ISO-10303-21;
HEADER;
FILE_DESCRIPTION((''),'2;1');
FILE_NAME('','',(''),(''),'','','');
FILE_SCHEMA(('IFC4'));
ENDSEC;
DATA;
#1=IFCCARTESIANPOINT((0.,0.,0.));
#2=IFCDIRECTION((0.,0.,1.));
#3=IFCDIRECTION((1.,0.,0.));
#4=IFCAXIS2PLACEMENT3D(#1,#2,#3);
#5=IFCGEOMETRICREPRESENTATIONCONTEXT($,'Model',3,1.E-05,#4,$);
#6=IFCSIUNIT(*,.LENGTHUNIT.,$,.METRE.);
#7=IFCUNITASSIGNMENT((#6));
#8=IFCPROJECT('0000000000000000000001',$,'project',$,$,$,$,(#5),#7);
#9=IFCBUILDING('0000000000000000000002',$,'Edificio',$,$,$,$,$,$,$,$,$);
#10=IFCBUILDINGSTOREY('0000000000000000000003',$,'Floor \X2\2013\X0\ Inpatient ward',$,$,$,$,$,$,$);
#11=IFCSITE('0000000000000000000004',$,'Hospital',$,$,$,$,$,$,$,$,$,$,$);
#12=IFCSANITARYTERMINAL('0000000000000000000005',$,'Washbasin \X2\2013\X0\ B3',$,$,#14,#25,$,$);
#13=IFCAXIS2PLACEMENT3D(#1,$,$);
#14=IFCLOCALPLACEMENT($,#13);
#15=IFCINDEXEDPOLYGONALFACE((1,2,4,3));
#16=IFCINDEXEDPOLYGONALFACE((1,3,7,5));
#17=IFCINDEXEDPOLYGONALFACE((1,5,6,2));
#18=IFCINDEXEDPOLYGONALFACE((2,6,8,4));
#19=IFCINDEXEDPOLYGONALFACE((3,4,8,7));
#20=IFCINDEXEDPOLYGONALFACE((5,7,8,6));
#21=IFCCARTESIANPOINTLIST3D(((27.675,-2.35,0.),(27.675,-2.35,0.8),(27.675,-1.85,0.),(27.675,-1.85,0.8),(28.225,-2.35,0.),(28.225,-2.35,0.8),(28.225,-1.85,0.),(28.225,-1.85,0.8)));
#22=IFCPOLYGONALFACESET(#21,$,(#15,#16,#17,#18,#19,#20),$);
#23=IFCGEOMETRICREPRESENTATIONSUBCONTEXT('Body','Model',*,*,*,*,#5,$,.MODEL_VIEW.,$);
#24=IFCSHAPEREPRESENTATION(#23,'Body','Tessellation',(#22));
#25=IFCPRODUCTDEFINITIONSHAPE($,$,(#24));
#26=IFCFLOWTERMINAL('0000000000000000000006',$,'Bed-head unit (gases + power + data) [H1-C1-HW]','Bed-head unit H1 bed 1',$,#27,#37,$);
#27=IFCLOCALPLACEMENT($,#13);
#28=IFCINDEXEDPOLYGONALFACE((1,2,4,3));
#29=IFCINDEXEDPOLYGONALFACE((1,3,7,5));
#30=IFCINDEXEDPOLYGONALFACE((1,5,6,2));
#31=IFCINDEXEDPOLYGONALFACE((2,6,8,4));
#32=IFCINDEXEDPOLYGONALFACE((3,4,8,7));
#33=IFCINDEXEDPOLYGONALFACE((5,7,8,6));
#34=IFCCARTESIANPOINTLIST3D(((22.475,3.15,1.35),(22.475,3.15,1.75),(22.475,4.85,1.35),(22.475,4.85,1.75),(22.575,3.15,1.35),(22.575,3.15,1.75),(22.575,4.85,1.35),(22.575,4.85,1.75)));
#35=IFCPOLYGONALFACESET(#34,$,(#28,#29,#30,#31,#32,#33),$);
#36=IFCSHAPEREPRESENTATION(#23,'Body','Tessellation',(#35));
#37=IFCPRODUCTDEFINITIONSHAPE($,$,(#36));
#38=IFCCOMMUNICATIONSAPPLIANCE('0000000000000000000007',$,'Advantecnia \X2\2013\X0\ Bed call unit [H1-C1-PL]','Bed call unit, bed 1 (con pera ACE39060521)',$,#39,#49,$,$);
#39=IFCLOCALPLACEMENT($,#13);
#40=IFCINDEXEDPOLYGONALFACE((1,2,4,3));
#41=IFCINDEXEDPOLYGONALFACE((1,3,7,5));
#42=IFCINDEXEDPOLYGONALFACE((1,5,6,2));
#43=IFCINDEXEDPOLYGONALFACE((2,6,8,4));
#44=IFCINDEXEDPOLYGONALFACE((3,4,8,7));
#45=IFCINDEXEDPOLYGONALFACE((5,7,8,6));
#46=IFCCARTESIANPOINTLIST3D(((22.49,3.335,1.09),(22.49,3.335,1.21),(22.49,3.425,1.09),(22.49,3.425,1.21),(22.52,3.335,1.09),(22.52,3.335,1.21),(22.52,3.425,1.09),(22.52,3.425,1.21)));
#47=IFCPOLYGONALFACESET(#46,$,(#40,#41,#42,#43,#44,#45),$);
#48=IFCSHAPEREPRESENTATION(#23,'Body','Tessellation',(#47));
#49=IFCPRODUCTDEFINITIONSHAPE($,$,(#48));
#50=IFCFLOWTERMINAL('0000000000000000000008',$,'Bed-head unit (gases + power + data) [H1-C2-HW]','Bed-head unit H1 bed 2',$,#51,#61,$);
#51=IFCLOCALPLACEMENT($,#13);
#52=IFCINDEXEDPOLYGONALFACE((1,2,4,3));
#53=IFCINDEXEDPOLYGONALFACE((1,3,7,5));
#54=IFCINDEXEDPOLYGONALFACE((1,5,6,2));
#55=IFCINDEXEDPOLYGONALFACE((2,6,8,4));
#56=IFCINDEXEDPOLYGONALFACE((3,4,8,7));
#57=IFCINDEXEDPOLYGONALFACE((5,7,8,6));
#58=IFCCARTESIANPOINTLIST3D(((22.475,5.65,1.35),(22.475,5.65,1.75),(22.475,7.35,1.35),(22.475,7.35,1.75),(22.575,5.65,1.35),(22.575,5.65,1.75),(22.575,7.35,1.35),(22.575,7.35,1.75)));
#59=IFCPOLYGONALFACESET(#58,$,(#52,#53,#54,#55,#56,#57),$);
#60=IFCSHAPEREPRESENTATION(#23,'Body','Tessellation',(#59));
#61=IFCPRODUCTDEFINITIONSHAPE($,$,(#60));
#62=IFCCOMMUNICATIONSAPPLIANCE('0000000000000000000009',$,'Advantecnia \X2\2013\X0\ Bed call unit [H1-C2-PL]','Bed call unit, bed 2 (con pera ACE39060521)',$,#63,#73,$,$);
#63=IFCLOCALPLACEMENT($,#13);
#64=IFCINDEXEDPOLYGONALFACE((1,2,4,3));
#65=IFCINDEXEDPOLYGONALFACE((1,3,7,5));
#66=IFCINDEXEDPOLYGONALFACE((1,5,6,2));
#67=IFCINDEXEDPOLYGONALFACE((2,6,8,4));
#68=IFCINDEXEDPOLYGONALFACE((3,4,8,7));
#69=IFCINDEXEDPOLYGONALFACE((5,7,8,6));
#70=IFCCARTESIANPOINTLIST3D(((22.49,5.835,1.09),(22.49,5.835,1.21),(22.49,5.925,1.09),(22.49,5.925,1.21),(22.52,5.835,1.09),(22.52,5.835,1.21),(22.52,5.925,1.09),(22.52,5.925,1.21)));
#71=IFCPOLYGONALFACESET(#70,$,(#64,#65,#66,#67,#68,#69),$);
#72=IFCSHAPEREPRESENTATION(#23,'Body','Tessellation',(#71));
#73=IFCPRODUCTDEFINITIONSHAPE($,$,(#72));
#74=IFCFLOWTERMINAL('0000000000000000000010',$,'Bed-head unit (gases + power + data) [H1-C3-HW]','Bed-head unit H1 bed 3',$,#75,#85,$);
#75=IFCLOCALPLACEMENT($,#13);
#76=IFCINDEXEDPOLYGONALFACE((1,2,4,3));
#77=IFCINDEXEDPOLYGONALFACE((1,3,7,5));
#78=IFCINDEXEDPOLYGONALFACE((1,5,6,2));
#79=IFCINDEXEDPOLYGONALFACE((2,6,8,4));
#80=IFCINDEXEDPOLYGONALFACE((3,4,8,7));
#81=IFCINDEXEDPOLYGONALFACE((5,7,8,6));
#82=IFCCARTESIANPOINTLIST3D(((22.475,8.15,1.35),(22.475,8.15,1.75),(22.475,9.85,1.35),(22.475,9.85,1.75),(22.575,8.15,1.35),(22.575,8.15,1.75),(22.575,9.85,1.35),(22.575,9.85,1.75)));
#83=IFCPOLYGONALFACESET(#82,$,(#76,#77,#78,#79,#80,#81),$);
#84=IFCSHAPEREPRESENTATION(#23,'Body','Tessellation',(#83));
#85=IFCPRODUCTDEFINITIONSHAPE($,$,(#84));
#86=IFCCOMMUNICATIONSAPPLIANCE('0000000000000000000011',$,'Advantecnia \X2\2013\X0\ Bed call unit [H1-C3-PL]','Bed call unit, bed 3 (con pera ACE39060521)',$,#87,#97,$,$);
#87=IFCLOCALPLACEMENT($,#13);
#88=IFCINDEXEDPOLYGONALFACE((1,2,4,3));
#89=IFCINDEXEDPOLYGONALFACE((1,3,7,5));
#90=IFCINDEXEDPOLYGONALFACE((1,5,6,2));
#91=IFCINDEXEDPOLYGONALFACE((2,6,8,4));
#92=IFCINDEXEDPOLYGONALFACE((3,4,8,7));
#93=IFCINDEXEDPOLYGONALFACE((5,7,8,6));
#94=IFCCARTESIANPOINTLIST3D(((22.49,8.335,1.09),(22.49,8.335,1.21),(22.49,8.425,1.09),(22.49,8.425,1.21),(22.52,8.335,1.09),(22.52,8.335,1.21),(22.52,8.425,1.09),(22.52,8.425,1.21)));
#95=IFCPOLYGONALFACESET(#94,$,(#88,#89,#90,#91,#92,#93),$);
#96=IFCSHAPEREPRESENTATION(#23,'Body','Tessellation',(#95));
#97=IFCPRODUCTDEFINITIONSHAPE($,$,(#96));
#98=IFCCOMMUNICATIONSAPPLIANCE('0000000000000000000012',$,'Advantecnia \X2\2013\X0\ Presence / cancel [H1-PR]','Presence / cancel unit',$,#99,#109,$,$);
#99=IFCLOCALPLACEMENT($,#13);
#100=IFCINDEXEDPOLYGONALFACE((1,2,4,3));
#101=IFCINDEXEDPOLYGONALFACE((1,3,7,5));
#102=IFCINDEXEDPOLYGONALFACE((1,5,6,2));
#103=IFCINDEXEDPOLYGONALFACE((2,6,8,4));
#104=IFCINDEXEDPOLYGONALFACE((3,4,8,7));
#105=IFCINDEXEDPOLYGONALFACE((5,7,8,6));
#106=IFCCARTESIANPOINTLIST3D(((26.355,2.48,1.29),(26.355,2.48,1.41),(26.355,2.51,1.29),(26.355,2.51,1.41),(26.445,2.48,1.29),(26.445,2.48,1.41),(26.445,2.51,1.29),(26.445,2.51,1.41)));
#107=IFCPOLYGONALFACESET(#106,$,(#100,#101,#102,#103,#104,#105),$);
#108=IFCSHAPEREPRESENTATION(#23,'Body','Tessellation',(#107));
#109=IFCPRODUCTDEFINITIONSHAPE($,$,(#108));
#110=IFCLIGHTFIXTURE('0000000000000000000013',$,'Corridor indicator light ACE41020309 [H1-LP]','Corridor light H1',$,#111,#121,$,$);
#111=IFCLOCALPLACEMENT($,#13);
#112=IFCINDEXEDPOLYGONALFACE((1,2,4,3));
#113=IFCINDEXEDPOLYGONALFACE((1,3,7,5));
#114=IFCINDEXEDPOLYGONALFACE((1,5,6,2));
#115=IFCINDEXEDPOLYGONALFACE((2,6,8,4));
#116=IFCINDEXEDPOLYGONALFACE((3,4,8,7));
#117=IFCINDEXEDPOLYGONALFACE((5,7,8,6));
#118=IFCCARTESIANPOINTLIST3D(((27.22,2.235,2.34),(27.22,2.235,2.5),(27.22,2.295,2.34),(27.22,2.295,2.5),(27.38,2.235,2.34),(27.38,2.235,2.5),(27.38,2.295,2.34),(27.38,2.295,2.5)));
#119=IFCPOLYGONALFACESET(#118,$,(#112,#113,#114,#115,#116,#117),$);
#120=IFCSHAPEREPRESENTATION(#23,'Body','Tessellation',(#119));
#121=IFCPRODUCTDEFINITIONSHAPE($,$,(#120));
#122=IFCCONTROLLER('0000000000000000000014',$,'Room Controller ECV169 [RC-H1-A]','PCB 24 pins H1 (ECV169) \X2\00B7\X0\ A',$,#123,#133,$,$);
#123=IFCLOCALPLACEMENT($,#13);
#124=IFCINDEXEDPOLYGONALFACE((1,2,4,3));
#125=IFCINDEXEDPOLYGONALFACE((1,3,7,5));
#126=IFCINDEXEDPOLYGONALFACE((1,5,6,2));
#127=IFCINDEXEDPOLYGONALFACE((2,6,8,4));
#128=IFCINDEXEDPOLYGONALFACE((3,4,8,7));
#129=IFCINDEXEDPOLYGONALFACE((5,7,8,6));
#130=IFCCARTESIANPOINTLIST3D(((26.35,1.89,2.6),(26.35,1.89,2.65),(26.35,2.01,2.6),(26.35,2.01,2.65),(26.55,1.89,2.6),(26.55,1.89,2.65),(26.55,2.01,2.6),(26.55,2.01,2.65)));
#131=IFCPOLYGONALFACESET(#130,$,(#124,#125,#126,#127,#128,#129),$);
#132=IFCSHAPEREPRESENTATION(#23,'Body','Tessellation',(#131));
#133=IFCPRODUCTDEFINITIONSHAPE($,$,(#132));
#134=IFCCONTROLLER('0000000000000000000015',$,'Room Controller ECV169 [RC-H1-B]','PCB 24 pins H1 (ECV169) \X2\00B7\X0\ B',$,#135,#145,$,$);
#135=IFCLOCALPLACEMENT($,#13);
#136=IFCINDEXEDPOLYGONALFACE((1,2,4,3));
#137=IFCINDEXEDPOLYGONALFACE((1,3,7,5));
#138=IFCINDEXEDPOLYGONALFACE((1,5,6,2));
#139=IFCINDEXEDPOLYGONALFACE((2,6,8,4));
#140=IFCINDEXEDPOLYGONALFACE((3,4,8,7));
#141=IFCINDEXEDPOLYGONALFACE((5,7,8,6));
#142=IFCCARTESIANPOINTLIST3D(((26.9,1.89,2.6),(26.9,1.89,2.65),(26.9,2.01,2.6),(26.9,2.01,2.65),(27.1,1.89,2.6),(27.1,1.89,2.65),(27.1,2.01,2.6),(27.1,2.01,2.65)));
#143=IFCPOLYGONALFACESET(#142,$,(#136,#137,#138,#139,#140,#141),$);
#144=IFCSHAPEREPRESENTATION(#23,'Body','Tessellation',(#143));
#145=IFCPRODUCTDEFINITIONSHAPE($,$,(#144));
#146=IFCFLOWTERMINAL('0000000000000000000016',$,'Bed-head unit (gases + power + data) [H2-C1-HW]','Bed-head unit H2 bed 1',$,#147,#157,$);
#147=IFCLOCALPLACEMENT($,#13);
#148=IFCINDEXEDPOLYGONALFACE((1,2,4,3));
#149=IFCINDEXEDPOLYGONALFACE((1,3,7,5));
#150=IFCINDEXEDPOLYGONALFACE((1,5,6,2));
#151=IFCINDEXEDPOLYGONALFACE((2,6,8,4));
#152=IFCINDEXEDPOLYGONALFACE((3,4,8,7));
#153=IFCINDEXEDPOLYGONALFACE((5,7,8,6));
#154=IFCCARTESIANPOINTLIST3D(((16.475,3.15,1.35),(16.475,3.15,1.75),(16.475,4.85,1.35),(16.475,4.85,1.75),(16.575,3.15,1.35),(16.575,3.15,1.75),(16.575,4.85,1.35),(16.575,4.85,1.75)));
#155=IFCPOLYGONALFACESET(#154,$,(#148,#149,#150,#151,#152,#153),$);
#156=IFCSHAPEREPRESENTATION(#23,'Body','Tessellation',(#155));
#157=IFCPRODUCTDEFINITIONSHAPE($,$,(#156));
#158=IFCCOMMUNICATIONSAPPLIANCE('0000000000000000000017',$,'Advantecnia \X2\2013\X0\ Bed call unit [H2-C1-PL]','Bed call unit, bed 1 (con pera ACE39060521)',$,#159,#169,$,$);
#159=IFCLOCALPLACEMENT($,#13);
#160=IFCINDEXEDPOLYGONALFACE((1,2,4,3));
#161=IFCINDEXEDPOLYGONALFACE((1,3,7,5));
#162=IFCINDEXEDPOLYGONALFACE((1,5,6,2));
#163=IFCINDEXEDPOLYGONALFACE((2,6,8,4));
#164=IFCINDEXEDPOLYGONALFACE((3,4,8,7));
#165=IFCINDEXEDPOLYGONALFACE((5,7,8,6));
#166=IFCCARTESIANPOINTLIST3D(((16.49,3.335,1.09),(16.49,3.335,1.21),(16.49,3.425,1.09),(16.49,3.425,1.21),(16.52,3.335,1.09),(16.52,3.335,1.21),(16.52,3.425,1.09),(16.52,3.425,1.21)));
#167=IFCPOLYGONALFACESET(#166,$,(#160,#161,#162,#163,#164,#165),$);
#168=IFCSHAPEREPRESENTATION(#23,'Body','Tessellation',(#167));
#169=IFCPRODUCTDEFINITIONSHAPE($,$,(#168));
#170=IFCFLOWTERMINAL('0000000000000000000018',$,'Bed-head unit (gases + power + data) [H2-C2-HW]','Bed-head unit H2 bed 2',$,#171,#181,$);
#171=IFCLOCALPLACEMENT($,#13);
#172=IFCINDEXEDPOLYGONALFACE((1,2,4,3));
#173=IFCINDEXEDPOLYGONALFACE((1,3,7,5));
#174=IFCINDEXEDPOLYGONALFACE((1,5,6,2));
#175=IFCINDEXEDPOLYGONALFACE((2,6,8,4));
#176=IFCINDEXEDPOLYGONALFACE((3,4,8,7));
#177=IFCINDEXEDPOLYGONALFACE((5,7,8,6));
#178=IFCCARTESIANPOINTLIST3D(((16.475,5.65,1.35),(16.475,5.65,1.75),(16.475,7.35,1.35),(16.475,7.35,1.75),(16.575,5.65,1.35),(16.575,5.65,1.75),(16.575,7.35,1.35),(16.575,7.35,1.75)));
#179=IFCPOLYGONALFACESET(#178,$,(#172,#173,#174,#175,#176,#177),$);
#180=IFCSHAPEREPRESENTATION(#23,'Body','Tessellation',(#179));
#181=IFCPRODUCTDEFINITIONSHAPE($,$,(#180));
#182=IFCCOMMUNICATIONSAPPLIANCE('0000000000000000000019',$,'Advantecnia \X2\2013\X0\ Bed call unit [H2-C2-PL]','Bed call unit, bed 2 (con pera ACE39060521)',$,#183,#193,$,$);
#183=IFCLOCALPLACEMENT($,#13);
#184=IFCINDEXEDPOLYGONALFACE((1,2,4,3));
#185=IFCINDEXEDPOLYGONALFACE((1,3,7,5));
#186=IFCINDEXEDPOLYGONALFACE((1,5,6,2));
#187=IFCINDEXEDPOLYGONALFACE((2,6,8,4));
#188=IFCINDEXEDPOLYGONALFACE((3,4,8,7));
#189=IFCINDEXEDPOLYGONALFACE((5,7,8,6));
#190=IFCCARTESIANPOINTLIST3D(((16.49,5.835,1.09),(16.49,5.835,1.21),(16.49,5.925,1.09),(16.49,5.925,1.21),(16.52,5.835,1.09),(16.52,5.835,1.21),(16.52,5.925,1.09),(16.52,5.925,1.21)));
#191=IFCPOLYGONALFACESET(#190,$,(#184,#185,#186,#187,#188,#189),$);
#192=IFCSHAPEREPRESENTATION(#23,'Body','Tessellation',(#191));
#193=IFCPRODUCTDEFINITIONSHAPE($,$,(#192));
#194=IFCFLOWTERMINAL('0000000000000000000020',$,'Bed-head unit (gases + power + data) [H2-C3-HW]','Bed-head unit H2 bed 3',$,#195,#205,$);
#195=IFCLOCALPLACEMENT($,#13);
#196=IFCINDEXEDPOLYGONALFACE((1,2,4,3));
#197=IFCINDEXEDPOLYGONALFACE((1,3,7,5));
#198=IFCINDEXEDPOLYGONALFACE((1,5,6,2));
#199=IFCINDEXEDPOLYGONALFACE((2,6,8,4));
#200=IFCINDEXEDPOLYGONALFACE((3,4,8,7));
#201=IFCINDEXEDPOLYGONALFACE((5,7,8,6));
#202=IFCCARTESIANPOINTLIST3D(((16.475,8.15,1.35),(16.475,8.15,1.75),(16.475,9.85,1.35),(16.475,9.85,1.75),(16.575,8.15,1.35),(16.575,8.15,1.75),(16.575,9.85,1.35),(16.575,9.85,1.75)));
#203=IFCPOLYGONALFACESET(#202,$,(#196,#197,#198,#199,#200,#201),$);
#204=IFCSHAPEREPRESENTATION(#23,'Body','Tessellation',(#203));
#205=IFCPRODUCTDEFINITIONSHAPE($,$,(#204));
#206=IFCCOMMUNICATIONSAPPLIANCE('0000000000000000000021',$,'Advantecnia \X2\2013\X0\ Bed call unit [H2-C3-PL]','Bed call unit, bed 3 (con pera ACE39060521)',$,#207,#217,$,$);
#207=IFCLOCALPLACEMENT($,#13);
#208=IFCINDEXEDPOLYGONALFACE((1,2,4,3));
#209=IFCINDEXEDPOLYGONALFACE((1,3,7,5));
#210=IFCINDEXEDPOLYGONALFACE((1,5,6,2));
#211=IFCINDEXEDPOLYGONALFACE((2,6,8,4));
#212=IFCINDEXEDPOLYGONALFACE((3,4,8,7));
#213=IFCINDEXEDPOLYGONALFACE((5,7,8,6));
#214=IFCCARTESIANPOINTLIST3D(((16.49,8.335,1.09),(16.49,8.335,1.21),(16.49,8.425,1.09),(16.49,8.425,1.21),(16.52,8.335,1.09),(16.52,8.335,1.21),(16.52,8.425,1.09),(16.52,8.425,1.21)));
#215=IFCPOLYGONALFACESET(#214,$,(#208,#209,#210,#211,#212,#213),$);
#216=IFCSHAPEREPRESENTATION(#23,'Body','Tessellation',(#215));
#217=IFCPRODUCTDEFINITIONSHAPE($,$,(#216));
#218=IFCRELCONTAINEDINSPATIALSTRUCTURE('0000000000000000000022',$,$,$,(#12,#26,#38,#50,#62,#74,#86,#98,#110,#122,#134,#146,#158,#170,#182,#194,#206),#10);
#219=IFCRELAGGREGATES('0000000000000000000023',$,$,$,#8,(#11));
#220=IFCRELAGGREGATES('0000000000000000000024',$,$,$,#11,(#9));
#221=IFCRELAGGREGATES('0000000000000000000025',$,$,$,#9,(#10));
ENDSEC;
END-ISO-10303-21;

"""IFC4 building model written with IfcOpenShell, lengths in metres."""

from ifc_helpers import new_model, si_unit, frame, origin_with_axes, context, subcontext, project, spatial, line, indexed_curve, outline, extrude, element, save


model = new_model("IFC4")

# Units and contexts
model_context = context("Model", 3, precision=1e-05, world=origin_with_axes())
body_context = subcontext(model_context, "Body", "Model", "MODEL_VIEW")
ifc_project = project(units=[si_unit("LENGTHUNIT", "METRE")], contexts=[model_context])

# Site, building, storey
site = spatial("IfcSite", under=ifc_project, Name="Hospital")
building = spatial("IfcBuilding", under=site, Name="Edificio")
storey = spatial("IfcBuildingStorey", under=building, Name="Floor – Inpatient ward")

# Sanitary terminal
element("IfcSanitaryTerminal", 1, inside=storey, Name="Washbasin – B3", context=body_context, shape_type="SweptSolid", body=[
    extrude(outline(indexed_curve([(0.0, 0.0), (0.55, 0.0), (0.55, 0.5), (0.0, 0.5)], segments=[line(1, 2, 3, 4, 1)])), frame((27.675, -2.35, 0.0), z_axis=(0.0, 0.0, 1.0), x_axis=(1.0, 0.0, 0.0)), (0.0, 0.0, 1.0), 0.8),
])

# Flow terminal
element("IfcFlowTerminal", 2, inside=storey, Name="Bed-head unit (gases + power + data) [H1-C1-HW]", Description="Bed-head unit H1 bed 1", context=body_context, shape_type="SweptSolid", body=[
    extrude(outline(indexed_curve([(0.0, 0.0), (0.1, 0.0), (0.1, 1.7), (0.0, 1.7)], segments=[line(1, 2, 3, 4, 1)])), frame((22.475, 3.15, 1.35), z_axis=(0.0, 0.0, 1.0), x_axis=(1.0, 0.0, 0.0)), (0.0, 0.0, 1.0), 0.4),
])

# Communications appliance
element("IfcCommunicationsAppliance", 3, inside=storey, Name="Advantecnia – Bed call unit [H1-C1-PL]", Description="Bed call unit, bed 1 (con pera ACE39060521)", context=body_context, shape_type="SweptSolid", body=[
    extrude(outline(indexed_curve([(0.0, 0.0), (0.03, 0.0), (0.03, 0.09), (0.0, 0.09)], segments=[line(1, 2, 3, 4, 1)])), frame((22.49, 3.335, 1.09), z_axis=(0.0, 0.0, 1.0), x_axis=(1.0, 0.0, 0.0)), (0.0, 0.0, 1.0), 0.12),
])

# Flow terminal
element("IfcFlowTerminal", 4, inside=storey, Name="Bed-head unit (gases + power + data) [H1-C2-HW]", Description="Bed-head unit H1 bed 2", context=body_context, shape_type="SweptSolid", body=[
    extrude(outline(indexed_curve([(0.0, 0.0), (0.1, 0.0), (0.1, 1.7), (0.0, 1.7)], segments=[line(1, 2, 3, 4, 1)])), frame((22.475, 5.65, 1.35), z_axis=(0.0, 0.0, 1.0), x_axis=(1.0, 0.0, 0.0)), (0.0, 0.0, 1.0), 0.4),
])

# Communications appliance
element("IfcCommunicationsAppliance", 5, inside=storey, Name="Advantecnia – Bed call unit [H1-C2-PL]", Description="Bed call unit, bed 2 (con pera ACE39060521)", context=body_context, shape_type="SweptSolid", body=[
    extrude(outline(indexed_curve([(0.0, 0.0), (0.03, 0.0), (0.03, 0.09), (0.0, 0.09)], segments=[line(1, 2, 3, 4, 1)])), frame((22.49, 5.835, 1.09), z_axis=(0.0, 0.0, 1.0), x_axis=(1.0, 0.0, 0.0)), (0.0, 0.0, 1.0), 0.12),
])

# Flow terminal
element("IfcFlowTerminal", 6, inside=storey, Name="Bed-head unit (gases + power + data) [H1-C3-HW]", Description="Bed-head unit H1 bed 3", context=body_context, shape_type="SweptSolid", body=[
    extrude(outline(indexed_curve([(0.0, 0.0), (0.1, 0.0), (0.1, 1.7), (0.0, 1.7)], segments=[line(1, 2, 3, 4, 1)])), frame((22.475, 8.15, 1.35), z_axis=(0.0, 0.0, 1.0), x_axis=(1.0, 0.0, 0.0)), (0.0, 0.0, 1.0), 0.4),
])

# Communications appliances
element("IfcCommunicationsAppliance", 7, inside=storey, Name="Advantecnia – Bed call unit [H1-C3-PL]", Description="Bed call unit, bed 3 (con pera ACE39060521)", context=body_context, shape_type="SweptSolid", body=[
    extrude(outline(indexed_curve([(0.0, 0.0), (0.03, 0.0), (0.03, 0.09), (0.0, 0.09)], segments=[line(1, 2, 3, 4, 1)])), frame((22.49, 8.335, 1.09), z_axis=(0.0, 0.0, 1.0), x_axis=(1.0, 0.0, 0.0)), (0.0, 0.0, 1.0), 0.12),
])
element("IfcCommunicationsAppliance", 8, inside=storey, Name="Advantecnia – Presence / cancel [H1-PR]", Description="Presence / cancel unit", context=body_context, shape_type="SweptSolid", body=[
    extrude(outline(indexed_curve([(0.0, 0.0), (0.09, 0.0), (0.09, 0.03), (0.0, 0.03)], segments=[line(1, 2, 3, 4, 1)])), frame((26.355, 2.48, 1.29), z_axis=(0.0, 0.0, 1.0), x_axis=(1.0, 0.0, 0.0)), (0.0, 0.0, 1.0), 0.12),
])

# Light fixture
element("IfcLightFixture", 9, inside=storey, Name="Corridor indicator light ACE41020309 [H1-LP]", Description="Corridor light H1", context=body_context, shape_type="SweptSolid", body=[
    extrude(outline(indexed_curve([(0.0, 0.0), (0.16, 0.0), (0.16, 0.06), (0.0, 0.06)], segments=[line(1, 2, 3, 4, 1)])), frame((27.22, 2.235, 2.34), z_axis=(0.0, 0.0, 1.0), x_axis=(1.0, 0.0, 0.0)), (0.0, 0.0, 1.0), 0.16),
])

# Controllers
element("IfcController", 10, inside=storey, Name="Room Controller ECV169 [RC-H1-A]", Description="PCB 24 pins H1 (ECV169) · A", context=body_context, shape_type="SweptSolid", body=[
    extrude(outline(indexed_curve([(0.0, 0.0), (0.2, 0.0), (0.2, 0.12), (0.0, 0.12)], segments=[line(1, 2, 3, 4, 1)])), frame((26.35, 1.89, 2.6), z_axis=(0.0, 0.0, 1.0), x_axis=(1.0, 0.0, 0.0)), (0.0, 0.0, 1.0), 0.05),
])
element("IfcController", 11, inside=storey, Name="Room Controller ECV169 [RC-H1-B]", Description="PCB 24 pins H1 (ECV169) · B", context=body_context, shape_type="SweptSolid", body=[
    extrude(outline(indexed_curve([(0.0, 0.0), (0.2, 0.0), (0.2, 0.12), (0.0, 0.12)], segments=[line(1, 2, 3, 4, 1)])), frame((26.9, 1.89, 2.6), z_axis=(0.0, 0.0, 1.0), x_axis=(1.0, 0.0, 0.0)), (0.0, 0.0, 1.0), 0.05),
])

# Flow terminal
element("IfcFlowTerminal", 12, inside=storey, Name="Bed-head unit (gases + power + data) [H2-C1-HW]", Description="Bed-head unit H2 bed 1", context=body_context, shape_type="SweptSolid", body=[
    extrude(outline(indexed_curve([(0.0, 0.0), (0.1, 0.0), (0.1, 1.7), (0.0, 1.7)], segments=[line(1, 2, 3, 4, 1)])), frame((16.475, 3.15, 1.35), z_axis=(0.0, 0.0, 1.0), x_axis=(1.0, 0.0, 0.0)), (0.0, 0.0, 1.0), 0.4),
])

# Communications appliance
element("IfcCommunicationsAppliance", 13, inside=storey, Name="Advantecnia – Bed call unit [H2-C1-PL]", Description="Bed call unit, bed 1 (con pera ACE39060521)", context=body_context, shape_type="SweptSolid", body=[
    extrude(outline(indexed_curve([(0.0, 0.0), (0.03, 0.0), (0.03, 0.09), (0.0, 0.09)], segments=[line(1, 2, 3, 4, 1)])), frame((16.49, 3.335, 1.09), z_axis=(0.0, 0.0, 1.0), x_axis=(1.0, 0.0, 0.0)), (0.0, 0.0, 1.0), 0.12),
])

# Flow terminal
element("IfcFlowTerminal", 14, inside=storey, Name="Bed-head unit (gases + power + data) [H2-C2-HW]", Description="Bed-head unit H2 bed 2", context=body_context, shape_type="SweptSolid", body=[
    extrude(outline(indexed_curve([(0.0, 0.0), (0.1, 0.0), (0.1, 1.7), (0.0, 1.7)], segments=[line(1, 2, 3, 4, 1)])), frame((16.475, 5.65, 1.35), z_axis=(0.0, 0.0, 1.0), x_axis=(1.0, 0.0, 0.0)), (0.0, 0.0, 1.0), 0.4),
])

# Communications appliance
element("IfcCommunicationsAppliance", 15, inside=storey, Name="Advantecnia – Bed call unit [H2-C2-PL]", Description="Bed call unit, bed 2 (con pera ACE39060521)", context=body_context, shape_type="SweptSolid", body=[
    extrude(outline(indexed_curve([(0.0, 0.0), (0.03, 0.0), (0.03, 0.09), (0.0, 0.09)], segments=[line(1, 2, 3, 4, 1)])), frame((16.49, 5.835, 1.09), z_axis=(0.0, 0.0, 1.0), x_axis=(1.0, 0.0, 0.0)), (0.0, 0.0, 1.0), 0.12),
])

# Flow terminal
element("IfcFlowTerminal", 16, inside=storey, Name="Bed-head unit (gases + power + data) [H2-C3-HW]", Description="Bed-head unit H2 bed 3", context=body_context, shape_type="SweptSolid", body=[
    extrude(outline(indexed_curve([(0.0, 0.0), (0.1, 0.0), (0.1, 1.7), (0.0, 1.7)], segments=[line(1, 2, 3, 4, 1)])), frame((16.475, 8.15, 1.35), z_axis=(0.0, 0.0, 1.0), x_axis=(1.0, 0.0, 0.0)), (0.0, 0.0, 1.0), 0.4),
])

# Communications appliance
element("IfcCommunicationsAppliance", 17, inside=storey, Name="Advantecnia – Bed call unit [H2-C3-PL]", Description="Bed call unit, bed 3 (con pera ACE39060521)", context=body_context, shape_type="SweptSolid", body=[
    extrude(outline(indexed_curve([(0.0, 0.0), (0.03, 0.0), (0.03, 0.09), (0.0, 0.09)], segments=[line(1, 2, 3, 4, 1)])), frame((16.49, 8.335, 1.09), z_axis=(0.0, 0.0, 1.0), x_axis=(1.0, 0.0, 0.0)), (0.0, 0.0, 1.0), 0.12),
])

save(model, "model.ifc")
